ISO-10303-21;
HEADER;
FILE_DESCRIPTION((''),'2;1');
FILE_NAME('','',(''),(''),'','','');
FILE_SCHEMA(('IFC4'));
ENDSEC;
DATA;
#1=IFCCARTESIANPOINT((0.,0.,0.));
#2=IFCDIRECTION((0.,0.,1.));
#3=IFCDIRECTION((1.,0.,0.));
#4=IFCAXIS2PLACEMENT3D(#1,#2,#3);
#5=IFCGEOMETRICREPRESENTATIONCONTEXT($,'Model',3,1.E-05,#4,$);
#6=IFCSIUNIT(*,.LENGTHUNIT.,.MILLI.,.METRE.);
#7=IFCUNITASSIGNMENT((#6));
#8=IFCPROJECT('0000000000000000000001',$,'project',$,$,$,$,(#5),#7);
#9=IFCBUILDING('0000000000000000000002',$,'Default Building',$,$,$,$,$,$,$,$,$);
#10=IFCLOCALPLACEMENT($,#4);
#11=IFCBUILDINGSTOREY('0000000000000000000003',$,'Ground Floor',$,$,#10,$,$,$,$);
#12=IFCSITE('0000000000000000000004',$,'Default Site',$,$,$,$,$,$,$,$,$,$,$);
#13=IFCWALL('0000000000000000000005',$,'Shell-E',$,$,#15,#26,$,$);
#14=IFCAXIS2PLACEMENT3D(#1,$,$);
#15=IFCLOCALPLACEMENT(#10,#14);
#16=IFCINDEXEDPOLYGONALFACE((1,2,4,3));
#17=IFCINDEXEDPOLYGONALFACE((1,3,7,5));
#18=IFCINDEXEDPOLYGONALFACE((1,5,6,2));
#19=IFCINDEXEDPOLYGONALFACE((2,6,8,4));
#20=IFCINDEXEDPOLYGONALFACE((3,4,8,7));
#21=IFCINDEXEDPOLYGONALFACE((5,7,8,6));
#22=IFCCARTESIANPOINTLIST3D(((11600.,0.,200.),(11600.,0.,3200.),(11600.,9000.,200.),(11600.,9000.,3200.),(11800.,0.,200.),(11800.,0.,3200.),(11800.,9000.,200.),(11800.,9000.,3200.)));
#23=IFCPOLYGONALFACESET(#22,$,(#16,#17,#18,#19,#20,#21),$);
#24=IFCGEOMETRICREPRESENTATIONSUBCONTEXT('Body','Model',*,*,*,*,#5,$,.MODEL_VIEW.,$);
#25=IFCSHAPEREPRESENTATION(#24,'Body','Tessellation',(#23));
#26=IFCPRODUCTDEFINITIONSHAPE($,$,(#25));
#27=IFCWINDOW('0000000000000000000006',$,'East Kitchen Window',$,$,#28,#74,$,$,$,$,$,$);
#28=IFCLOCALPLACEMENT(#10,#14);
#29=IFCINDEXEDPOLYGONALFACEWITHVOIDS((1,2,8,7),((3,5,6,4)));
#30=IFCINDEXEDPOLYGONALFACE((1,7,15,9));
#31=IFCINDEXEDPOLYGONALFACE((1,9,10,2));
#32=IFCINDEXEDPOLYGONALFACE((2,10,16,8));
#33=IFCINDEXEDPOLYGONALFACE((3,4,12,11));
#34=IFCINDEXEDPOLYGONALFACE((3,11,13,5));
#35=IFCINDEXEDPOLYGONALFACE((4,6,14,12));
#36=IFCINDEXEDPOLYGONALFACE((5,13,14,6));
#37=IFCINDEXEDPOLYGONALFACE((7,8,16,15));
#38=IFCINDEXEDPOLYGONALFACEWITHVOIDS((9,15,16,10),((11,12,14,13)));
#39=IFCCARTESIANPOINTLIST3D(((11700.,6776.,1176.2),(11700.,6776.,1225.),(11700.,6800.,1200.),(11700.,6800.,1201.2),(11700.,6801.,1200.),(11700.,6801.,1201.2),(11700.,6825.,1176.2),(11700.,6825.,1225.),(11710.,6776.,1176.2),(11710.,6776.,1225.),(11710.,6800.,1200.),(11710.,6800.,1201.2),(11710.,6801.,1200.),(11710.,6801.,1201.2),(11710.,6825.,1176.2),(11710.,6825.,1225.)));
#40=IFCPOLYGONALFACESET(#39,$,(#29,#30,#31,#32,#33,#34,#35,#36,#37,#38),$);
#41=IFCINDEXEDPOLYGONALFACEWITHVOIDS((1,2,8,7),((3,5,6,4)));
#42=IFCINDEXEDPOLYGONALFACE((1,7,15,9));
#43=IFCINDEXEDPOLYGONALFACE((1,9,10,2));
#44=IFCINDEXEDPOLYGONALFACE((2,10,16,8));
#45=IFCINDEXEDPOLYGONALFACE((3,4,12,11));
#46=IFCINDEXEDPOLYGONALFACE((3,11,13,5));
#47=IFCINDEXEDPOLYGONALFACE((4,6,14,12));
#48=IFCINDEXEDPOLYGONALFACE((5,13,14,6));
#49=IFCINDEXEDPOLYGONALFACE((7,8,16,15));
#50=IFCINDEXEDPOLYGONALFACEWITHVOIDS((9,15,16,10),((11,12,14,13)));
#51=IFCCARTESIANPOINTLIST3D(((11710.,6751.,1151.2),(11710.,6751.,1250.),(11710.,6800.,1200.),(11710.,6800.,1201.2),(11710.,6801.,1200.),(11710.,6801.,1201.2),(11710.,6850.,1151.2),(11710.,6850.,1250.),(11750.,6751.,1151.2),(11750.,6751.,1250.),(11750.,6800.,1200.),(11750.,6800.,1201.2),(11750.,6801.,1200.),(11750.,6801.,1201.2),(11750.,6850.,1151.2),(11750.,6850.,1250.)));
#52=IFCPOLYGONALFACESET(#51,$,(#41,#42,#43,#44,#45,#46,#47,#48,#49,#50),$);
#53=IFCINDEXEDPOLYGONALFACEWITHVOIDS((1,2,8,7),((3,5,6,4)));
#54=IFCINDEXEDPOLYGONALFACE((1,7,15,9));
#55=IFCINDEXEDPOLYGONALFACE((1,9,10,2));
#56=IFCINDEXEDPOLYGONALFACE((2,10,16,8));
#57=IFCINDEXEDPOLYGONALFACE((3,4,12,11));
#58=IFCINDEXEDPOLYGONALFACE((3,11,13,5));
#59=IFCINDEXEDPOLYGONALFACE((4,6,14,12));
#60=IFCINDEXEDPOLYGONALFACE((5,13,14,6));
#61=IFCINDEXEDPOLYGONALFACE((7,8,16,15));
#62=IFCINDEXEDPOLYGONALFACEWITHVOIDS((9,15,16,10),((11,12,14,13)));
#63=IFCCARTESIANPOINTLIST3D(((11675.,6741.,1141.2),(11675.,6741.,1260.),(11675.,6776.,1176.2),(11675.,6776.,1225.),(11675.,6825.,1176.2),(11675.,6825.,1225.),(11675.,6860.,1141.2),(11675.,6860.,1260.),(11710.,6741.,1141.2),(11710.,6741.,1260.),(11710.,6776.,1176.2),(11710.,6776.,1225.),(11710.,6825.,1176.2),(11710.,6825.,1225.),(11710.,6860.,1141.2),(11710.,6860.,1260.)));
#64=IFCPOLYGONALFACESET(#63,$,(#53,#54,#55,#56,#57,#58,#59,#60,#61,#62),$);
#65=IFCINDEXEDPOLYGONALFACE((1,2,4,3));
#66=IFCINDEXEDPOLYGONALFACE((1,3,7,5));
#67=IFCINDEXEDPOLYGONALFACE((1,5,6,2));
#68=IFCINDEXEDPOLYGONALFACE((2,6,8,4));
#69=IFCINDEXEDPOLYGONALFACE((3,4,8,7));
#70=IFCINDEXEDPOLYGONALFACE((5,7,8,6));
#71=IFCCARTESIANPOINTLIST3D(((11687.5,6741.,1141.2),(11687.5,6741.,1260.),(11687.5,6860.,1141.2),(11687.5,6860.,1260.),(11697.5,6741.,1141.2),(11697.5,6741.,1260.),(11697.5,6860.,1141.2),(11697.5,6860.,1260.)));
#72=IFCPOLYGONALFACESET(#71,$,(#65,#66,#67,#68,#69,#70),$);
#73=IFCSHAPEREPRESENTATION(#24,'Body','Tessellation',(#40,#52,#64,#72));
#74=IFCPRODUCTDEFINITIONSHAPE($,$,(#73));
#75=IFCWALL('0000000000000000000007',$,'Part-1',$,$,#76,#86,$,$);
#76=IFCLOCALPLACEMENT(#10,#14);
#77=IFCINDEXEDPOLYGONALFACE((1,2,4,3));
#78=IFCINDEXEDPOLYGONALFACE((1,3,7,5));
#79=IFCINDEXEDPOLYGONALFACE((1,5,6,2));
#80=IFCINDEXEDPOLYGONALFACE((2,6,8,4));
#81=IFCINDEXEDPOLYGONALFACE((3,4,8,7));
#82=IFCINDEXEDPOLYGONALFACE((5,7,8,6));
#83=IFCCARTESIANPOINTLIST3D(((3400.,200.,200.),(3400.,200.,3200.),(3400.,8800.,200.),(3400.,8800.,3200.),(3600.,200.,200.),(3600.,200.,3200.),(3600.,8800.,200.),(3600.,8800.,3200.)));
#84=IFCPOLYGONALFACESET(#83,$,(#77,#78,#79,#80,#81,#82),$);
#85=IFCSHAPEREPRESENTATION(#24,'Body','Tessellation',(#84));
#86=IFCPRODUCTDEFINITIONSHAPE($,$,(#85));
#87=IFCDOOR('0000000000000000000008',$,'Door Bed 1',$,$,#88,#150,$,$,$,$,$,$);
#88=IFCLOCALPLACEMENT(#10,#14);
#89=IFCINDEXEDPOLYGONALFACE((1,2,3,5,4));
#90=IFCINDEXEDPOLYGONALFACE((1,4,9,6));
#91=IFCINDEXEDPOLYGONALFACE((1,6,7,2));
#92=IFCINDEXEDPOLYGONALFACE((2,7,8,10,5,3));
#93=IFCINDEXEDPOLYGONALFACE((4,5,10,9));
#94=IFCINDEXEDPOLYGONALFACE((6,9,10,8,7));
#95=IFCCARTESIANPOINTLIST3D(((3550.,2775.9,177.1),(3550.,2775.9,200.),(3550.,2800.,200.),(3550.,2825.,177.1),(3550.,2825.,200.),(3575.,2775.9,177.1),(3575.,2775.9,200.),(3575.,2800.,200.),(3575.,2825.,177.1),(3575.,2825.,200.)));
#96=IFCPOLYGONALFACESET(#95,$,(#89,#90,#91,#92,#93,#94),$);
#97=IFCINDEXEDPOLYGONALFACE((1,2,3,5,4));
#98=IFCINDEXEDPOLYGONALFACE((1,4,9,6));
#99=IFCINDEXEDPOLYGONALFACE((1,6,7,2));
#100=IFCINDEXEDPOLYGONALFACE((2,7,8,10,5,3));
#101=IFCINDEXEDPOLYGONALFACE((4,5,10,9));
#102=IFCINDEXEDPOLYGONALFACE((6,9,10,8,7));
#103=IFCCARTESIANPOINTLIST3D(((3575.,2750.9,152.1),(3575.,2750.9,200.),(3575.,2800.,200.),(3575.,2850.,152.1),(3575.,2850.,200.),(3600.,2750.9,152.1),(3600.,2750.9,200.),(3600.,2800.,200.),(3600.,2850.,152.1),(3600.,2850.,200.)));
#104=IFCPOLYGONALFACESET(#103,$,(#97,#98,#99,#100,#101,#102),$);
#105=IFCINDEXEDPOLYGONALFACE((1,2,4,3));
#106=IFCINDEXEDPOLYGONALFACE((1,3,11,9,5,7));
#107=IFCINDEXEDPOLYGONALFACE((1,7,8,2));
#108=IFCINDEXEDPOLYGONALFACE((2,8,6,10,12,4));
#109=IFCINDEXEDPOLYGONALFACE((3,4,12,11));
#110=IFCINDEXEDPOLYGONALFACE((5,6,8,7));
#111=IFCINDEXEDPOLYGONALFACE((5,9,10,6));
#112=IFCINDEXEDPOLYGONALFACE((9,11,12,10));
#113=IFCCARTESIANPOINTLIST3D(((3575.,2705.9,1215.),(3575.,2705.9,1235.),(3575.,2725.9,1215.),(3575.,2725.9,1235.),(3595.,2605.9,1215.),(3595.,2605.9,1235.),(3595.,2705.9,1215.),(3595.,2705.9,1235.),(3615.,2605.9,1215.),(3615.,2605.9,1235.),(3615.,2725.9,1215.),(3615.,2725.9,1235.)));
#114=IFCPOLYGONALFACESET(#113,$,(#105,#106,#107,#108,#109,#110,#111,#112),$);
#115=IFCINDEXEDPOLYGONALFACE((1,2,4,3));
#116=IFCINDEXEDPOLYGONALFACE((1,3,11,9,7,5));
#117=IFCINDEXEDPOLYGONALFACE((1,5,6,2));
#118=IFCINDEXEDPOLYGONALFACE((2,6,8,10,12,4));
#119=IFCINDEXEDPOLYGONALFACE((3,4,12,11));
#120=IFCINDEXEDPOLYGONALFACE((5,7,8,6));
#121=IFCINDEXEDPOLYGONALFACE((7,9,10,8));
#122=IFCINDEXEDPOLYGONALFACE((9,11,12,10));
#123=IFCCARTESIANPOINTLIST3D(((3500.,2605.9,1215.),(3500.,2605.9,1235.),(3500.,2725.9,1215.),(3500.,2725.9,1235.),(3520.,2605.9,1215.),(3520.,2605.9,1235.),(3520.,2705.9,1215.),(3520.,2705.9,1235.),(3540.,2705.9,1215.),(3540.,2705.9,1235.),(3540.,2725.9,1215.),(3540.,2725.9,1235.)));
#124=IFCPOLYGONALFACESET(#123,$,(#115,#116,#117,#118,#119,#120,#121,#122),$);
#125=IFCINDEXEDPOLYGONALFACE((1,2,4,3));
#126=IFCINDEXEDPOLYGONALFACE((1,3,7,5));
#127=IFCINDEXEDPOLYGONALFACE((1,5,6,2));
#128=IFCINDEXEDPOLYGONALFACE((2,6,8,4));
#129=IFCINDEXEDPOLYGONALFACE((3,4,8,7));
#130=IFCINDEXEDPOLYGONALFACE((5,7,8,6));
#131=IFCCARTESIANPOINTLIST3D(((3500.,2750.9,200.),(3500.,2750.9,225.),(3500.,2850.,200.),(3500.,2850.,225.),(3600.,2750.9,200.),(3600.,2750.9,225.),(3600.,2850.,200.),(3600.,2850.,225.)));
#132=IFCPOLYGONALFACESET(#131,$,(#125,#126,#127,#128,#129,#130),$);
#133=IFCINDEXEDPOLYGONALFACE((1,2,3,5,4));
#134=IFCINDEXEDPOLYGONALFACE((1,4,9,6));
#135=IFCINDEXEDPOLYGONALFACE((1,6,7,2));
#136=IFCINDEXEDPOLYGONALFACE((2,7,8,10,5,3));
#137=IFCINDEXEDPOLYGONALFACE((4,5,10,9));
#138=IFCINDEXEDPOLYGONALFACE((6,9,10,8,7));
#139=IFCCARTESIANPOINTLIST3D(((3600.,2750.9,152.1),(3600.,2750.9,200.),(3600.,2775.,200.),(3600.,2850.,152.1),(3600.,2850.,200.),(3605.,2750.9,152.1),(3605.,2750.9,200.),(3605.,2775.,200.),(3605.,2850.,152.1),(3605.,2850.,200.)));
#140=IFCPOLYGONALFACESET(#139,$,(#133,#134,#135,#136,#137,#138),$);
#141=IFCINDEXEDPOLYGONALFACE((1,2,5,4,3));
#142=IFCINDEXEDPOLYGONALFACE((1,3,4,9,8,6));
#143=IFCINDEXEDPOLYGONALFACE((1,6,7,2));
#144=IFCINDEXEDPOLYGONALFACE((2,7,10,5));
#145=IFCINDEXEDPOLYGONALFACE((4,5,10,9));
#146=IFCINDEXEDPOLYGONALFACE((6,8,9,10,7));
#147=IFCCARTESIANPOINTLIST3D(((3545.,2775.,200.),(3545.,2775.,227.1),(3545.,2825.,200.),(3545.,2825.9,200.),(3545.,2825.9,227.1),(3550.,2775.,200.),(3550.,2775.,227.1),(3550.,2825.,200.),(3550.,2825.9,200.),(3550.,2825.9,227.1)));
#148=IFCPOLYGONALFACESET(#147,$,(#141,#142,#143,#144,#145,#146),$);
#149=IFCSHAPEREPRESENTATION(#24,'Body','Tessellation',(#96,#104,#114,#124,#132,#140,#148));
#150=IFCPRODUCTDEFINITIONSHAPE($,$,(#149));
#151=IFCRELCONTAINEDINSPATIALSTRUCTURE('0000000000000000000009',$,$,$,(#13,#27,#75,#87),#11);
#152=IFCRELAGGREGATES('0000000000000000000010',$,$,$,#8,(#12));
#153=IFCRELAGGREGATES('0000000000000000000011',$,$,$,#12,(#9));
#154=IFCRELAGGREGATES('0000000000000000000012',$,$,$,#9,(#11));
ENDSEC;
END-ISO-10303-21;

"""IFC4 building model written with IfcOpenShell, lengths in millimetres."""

from ifc_helpers import new_model, si_unit, frame, origin_with_axes, place, context, subcontext, project, spatial, line, indexed_curve, outline, extrude, element, fill, save


model = new_model("IFC4")

# Units and contexts
model_context = context("Model", 3, precision=1e-05, world=origin_with_axes())
body_context = subcontext(model_context, "Body", "Model", "MODEL_VIEW")
ifc_project = project(units=[si_unit("LENGTHUNIT", "METRE", prefix="MILLI")], contexts=[model_context])

# Site, building, storey
site = spatial("IfcSite", under=ifc_project, Name="Default Site")
building = spatial("IfcBuilding", under=site, Name="Default Building")
storey_placement = place(None, origin_with_axes())
storey = spatial("IfcBuildingStorey", under=building, at=storey_placement, Name="Ground Floor")

# Wall, opening, window
wall_1_placement = place(storey_placement, frame((0.0, 0.0, 200.0), z_axis=(0.0, 0.0, 1.0), x_axis=(1.0, 0.0, 0.0)))
wall_1 = element("IfcWall", 1, at=wall_1_placement, inside=storey, Name="Shell-E", context=body_context, shape_type="SweptSolid", body=[
    extrude(outline(indexed_curve([(11800.0, 0.0), (11800.0, 9000.0), (11600.0, 9000.0), (11600.0, 0.0), (11800.0, 0.0)])), None, (0.0, 0.0, 1.0), 3000.0),
])
opening_1_placement = place(wall_1_placement, frame((0.0, 0.0, 1000.0), z_axis=(0.0, 0.0, 1.0), x_axis=(1.0, 0.0, 0.0)))
opening_1 = element("IfcOpeningElement", 2, at=opening_1_placement, cuts=wall_1, context=body_context, shape_type="SweptSolid", body=[
    extrude(outline(indexed_curve([(11800.0, 6800.0), (12000.0, 6800.0), (12000.0, 7800.0), (11800.0, 7800.0), (11800.0, 6800.0)])), None, (0.0, 0.0, 1.0), 1200.0),
])
window_1_placement = place(storey_placement, frame((11800.0, 6800.0, 1200.0), z_axis=(0.0, 0.0, 1.0), x_axis=(0.0, 1.0, 0.0)))
window_1 = element("IfcWindow", 3, at=window_1_placement, inside=storey, Name="East Kitchen Window", context=body_context, shape_type="SweptSolid", body=[
    extrude(outline(indexed_curve([(0.0, 0.0), (1.0, 0.0), (1.0, 1.2), (0.0, 1.2)], segments=[line(1, 2, 3, 4, 1)]), holes=[indexed_curve([(25.0, 25.0), (-24.0, 25.0), (-24.0, -23.8), (25.0, -23.8)], segments=[line(1, 2, 3, 4, 1)])]), frame((0.0, 90.0, 0.0), z_axis=(0.0, -1.0, 0.0), x_axis=(1.0, 0.0, 0.0)), (0.0, 0.0, -1.0), 10.0),
    extrude(outline(indexed_curve([(0.0, 0.0), (1.0, 0.0), (1.0, 1.2), (0.0, 1.2)], segments=[line(1, 2, 3, 4, 1)]), holes=[indexed_curve([(50.0, 50.0), (-49.0, 50.0), (-49.0, -48.8), (50.0, -48.8)], segments=[line(1, 2, 3, 4, 1)])]), frame((0.0, 50.0, 0.0), z_axis=(0.0, -1.0, 0.0), x_axis=(1.0, 0.0, 0.0)), (0.0, 0.0, -1.0), 40.0),
    extrude(outline(indexed_curve([(0.0, 0.0), (-49.0, 0.0), (-49.0, -48.8), (0.0, -48.8)], segments=[line(1, 2, 3, 4, 1)]), holes=[indexed_curve([(35.0, 35.0), (-84.0, 35.0), (-84.0, -83.8), (35.0, -83.8)], segments=[line(1, 2, 3, 4, 1)])]), frame((25.0, 90.0, 25.0), z_axis=(0.0, -1.0, 0.0), x_axis=(1.0, 0.0, 0.0)), (0.0, 0.0, -1.0), 35.0),
    extrude(outline(indexed_curve([(35.0, 35.0), (-84.0, 35.0), (-84.0, -83.8), (35.0, -83.8)], segments=[line(1, 2, 3, 4, 1)])), frame((25.0, 102.5, 25.0), z_axis=(0.0, -1.0, 0.0), x_axis=(1.0, 0.0, 0.0)), (0.0, 0.0, -1.0), 10.0),
])
fill(opening_1, window_1)

# Wall, opening, door
wall_2_placement = place(storey_placement, frame((0.0, 0.0, 200.0), z_axis=(0.0, 0.0, 1.0), x_axis=(1.0, 0.0, 0.0)))
wall_2 = element("IfcWall", 4, at=wall_2_placement, inside=storey, Name="Part-1", context=body_context, shape_type="SweptSolid", body=[
    extrude(outline(indexed_curve([(3600.0, 200.0), (3600.0, 8800.0), (3400.0, 8800.0), (3400.0, 200.0), (3600.0, 200.0)])), None, (0.0, 0.0, 1.0), 3000.0),
])
opening_2_placement = place(wall_2_placement, origin_with_axes())
opening_2 = element("IfcOpeningElement", 5, at=opening_2_placement, cuts=wall_2, context=body_context, shape_type="SweptSolid", body=[
    extrude(outline(indexed_curve([(3600.0, 2800.0), (3800.0, 2800.0), (3800.0, 3700.0), (3600.0, 3700.0), (3600.0, 2800.0)])), None, (0.0, 0.0, 1.0), 2100.0),
])
door_1_placement = place(storey_placement, frame((3600.0, 2800.0, 200.0), z_axis=(0.0, 0.0, 1.0), x_axis=(0.0, 1.0, 0.0)))
door_1 = element("IfcDoor", 6, at=door_1_placement, inside=storey, Name="Door Bed 1", context=body_context, shape_type="SweptSolid", body=[
    extrude(outline(indexed_curve([(0.0, 0.0), (0.0, 2.1), (0.9, 2.1), (0.9, 0.0), (-24.1, 0.0), (-24.1, -22.9), (25.0, -22.9), (25.0, 0.0)], segments=[line(1, 2, 3, 4, 5, 6, 7, 8, 1)])), frame((0.0, 25.0, 0.0), z_axis=(0.0, -1.0, 0.0), x_axis=(1.0, 0.0, 0.0)), (0.0, 0.0, -1.0), 25.0),
    extrude(outline(indexed_curve([(0.0, 0.0), (0.0, 2.1), (0.9, 2.1), (0.9, 0.0), (-49.1, 0.0), (-49.1, -47.9), (50.0, -47.9), (50.0, 0.0)], segments=[line(1, 2, 3, 4, 5, 6, 7, 8, 1)])), frame((0.0, 0.0, 0.0), z_axis=(0.0, -1.0, 0.0), x_axis=(1.0, 0.0, 0.0)), (0.0, 0.0, -1.0), 25.0),
    extrude(outline(indexed_curve([(0.0, 0.0), (-49.1, 0.0), (-49.1, 35.0), (0.0, 35.0)], segments=[line(1, 2, 3, 4, 1)])), frame((25.0, 25.0, 25.0), z_axis=(0.0, 0.0, 1.0), x_axis=(1.0, 0.0, 0.0)), (0.0, 0.0, 1.0), -47.9),
    extrude(outline(indexed_curve([(0.0, 0.0), (0.0, -40.0), (-120.0, -40.0), (-120.0, -20.0), (-20.0, -20.0), (-20.0, 0.0)], segments=[line(1, 2, 3, 4, 5, 6, 1)])), frame((-74.1, 25.0, 1015.0), z_axis=(0.0, 0.0, 1.0), x_axis=(1.0, 0.0, 0.0)), (0.0, 0.0, 1.0), 20.0),
    extrude(outline(indexed_curve([(0.0, 0.0), (0.0, 40.0), (-120.0, 40.0), (-120.0, 20.0), (-20.0, 20.0), (-20.0, 0.0)], segments=[line(1, 2, 3, 4, 5, 6, 1)])), frame((-74.1, 60.0, 1015.0), z_axis=(0.0, 0.0, 1.0), x_axis=(1.0, 0.0, 0.0)), (0.0, 0.0, 1.0), 20.0),
    extrude(outline(indexed_curve([(0.0, 0.0), (-99.1, 0.0), (-99.1, 100.0), (0.0, 100.0)], segments=[line(1, 2, 3, 4, 1)])), frame((50.0, 0.0, 0.0), z_axis=(0.0, 0.0, 1.0), x_axis=(1.0, 0.0, 0.0)), (0.0, 0.0, 1.0), 25.0),
    extrude(outline(indexed_curve([(0.0, 0.0), (0.0, 27.1), (50.9, 27.1), (50.9, 0.0), (-24.1, 0.0), (-24.1, -47.9), (75.0, -47.9), (75.0, 0.0)], segments=[line(1, 2, 3, 4, 5, 6, 7, 8, 1)])), frame((-25.0, -5.0, 0.0), z_axis=(0.0, -1.0, 0.0), x_axis=(1.0, 0.0, 0.0)), (0.0, 0.0, -1.0), 5.0),
    extrude(outline(indexed_curve([(0.0, 0.0), (0.0, 27.1), (50.9, 27.1), (50.9, 0.0), (0.9, 0.0), (0.9, -22.9), (50.0, -22.9), (50.0, 0.0)], segments=[line(1, 2, 3, 4, 5, 6, 7, 8, 1)])), frame((-25.0, 50.0, 0.0), z_axis=(0.0, -1.0, 0.0), x_axis=(1.0, 0.0, 0.0)), (0.0, 0.0, -1.0), 5.0),
])
fill(opening_2, door_1)

save(model, "model.ifc")
